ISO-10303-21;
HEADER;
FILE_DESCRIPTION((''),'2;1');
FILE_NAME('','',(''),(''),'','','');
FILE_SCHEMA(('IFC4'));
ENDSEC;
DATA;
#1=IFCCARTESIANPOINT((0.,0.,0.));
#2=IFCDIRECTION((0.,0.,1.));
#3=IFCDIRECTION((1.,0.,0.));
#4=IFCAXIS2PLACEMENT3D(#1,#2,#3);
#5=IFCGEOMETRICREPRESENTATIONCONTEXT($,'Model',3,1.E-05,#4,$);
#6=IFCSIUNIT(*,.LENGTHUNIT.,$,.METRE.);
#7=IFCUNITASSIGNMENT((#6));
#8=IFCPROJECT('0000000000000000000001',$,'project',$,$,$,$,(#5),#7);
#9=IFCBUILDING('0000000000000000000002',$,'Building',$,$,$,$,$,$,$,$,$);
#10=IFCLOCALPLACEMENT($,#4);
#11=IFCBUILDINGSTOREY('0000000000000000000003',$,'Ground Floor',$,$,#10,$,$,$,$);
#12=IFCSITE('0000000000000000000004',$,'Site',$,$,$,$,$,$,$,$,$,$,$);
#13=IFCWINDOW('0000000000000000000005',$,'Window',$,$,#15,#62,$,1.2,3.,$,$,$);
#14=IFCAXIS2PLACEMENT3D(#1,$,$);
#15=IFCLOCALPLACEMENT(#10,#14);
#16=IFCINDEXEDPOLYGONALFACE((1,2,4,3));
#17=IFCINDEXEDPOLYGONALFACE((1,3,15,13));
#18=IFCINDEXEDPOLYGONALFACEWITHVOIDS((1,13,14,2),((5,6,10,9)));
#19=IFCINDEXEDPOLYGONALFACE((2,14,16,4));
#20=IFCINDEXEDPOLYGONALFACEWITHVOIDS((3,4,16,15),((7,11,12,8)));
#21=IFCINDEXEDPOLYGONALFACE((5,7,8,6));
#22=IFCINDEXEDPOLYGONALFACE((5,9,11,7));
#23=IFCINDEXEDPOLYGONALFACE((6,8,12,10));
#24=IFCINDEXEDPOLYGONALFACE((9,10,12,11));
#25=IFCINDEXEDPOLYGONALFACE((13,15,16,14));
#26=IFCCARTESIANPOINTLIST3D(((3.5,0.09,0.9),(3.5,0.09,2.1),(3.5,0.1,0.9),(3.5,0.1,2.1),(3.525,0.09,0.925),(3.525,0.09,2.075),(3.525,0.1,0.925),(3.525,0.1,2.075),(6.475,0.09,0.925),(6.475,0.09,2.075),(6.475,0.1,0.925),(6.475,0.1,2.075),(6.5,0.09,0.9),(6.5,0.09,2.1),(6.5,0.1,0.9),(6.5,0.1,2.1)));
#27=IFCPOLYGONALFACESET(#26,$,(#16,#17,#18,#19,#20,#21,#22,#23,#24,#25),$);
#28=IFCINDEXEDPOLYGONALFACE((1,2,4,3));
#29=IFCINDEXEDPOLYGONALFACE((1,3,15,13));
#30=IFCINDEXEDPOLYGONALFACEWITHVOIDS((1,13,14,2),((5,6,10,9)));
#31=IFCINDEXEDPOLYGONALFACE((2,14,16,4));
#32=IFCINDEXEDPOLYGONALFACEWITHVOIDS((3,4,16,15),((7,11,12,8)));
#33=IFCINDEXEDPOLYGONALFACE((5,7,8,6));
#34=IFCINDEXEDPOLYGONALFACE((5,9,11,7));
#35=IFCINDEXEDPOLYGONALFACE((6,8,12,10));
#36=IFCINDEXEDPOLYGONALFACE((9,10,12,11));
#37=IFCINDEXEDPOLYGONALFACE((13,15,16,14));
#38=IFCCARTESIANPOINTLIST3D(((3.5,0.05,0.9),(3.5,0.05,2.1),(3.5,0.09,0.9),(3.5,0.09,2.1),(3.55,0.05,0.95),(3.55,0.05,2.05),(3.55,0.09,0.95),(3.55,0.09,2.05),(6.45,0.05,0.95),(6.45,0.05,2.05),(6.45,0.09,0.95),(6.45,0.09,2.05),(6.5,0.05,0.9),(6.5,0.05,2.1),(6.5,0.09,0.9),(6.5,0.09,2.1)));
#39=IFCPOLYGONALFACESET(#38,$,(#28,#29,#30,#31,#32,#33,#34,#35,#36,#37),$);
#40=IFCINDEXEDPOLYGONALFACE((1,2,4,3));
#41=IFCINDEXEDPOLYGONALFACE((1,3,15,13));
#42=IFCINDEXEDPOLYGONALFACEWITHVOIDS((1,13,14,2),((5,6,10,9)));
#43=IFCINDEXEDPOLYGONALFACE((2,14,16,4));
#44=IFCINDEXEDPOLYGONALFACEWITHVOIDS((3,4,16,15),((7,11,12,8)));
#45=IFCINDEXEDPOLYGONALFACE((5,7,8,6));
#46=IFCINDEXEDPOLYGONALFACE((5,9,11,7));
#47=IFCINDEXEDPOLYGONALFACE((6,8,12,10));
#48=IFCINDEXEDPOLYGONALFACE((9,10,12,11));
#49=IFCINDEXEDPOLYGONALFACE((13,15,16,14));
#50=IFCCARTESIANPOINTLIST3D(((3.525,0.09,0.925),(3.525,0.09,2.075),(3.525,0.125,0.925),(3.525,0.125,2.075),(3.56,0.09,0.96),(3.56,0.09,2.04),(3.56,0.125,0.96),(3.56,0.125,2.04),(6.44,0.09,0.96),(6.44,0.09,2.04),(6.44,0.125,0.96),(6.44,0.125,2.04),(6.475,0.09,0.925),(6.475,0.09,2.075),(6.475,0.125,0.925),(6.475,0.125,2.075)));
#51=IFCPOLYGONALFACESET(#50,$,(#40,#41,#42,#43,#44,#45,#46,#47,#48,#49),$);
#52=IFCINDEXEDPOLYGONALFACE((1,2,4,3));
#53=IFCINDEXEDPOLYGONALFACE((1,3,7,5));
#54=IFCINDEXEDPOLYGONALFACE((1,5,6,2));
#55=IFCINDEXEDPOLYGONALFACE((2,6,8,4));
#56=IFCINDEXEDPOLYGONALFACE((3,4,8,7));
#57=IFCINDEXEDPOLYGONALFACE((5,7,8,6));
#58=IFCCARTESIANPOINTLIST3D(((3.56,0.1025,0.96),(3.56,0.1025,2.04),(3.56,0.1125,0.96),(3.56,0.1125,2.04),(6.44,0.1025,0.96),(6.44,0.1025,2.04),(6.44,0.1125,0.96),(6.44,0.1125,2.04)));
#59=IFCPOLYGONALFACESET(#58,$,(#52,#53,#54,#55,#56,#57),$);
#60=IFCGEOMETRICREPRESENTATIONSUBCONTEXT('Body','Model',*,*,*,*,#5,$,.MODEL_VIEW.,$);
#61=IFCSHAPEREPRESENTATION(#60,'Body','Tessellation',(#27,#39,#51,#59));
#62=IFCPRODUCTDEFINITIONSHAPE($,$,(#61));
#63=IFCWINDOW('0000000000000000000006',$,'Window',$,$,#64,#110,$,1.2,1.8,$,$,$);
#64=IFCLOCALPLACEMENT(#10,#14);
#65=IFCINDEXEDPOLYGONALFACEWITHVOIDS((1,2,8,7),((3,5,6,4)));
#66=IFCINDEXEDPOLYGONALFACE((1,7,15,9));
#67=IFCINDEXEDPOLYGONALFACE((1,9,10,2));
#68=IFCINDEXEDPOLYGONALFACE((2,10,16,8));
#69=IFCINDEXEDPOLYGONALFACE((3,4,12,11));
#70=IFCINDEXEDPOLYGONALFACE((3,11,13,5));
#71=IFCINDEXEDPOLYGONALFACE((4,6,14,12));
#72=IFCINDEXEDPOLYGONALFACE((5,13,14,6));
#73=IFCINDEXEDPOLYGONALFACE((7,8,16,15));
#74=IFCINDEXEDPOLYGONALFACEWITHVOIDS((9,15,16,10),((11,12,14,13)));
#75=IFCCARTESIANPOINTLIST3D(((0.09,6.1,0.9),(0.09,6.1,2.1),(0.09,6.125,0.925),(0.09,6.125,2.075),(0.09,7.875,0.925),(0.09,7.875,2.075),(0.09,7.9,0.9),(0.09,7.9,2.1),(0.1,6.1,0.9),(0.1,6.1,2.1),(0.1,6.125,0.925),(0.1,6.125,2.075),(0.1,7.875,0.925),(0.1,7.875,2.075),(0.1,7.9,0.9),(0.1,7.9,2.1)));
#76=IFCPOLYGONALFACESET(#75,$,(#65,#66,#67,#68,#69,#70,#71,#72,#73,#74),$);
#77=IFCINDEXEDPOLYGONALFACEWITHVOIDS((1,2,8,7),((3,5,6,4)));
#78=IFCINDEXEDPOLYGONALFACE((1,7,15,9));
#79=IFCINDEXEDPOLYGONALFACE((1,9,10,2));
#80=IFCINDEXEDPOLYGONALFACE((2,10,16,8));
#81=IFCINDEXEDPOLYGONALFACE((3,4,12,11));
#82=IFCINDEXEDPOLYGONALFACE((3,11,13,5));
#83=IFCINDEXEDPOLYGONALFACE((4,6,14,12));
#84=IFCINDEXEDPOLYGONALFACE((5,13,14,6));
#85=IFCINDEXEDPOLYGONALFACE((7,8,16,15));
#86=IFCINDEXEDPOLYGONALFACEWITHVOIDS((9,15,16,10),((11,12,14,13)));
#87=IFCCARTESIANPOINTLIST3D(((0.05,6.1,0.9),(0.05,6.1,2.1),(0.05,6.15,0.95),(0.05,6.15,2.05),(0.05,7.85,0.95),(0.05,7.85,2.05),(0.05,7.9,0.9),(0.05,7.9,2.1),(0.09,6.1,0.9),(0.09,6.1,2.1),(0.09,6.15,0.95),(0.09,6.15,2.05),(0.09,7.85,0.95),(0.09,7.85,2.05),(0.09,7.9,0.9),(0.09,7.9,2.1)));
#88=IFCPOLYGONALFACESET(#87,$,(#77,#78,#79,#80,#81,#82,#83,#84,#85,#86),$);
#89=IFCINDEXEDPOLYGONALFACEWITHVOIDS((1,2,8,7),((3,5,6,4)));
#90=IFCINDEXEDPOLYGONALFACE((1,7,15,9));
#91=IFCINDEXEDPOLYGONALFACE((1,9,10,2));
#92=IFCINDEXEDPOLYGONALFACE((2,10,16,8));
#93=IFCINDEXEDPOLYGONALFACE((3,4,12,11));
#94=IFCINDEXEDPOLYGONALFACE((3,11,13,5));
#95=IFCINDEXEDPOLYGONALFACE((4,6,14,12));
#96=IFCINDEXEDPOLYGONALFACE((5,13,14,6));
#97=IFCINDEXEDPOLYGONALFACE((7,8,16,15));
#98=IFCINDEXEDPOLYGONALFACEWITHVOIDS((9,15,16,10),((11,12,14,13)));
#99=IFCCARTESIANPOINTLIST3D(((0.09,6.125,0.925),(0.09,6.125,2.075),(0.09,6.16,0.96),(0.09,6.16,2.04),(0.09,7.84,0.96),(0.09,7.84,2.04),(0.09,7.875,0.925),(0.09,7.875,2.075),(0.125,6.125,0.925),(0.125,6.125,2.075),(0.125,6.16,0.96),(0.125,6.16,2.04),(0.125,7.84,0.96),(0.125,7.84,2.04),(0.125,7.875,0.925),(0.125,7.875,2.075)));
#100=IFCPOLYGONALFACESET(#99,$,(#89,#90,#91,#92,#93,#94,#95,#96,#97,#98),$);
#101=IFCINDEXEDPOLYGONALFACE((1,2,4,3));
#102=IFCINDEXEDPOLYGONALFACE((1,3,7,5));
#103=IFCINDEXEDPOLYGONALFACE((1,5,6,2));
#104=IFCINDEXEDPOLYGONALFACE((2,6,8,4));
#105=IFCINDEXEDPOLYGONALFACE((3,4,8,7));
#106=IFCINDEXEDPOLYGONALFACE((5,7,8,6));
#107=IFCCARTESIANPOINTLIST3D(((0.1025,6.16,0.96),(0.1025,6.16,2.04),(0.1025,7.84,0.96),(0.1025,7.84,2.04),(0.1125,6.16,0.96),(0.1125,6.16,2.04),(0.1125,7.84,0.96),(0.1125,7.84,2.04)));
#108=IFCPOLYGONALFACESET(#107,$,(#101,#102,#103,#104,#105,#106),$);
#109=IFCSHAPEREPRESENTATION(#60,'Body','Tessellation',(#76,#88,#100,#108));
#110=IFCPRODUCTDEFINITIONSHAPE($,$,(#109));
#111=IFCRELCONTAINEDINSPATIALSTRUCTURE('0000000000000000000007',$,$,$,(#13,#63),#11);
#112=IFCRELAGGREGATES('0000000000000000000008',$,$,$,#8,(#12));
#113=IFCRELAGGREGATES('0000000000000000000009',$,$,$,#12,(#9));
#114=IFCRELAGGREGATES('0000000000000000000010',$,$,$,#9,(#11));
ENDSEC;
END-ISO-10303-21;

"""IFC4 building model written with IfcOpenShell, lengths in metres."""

from ifc_helpers import new_model, si_unit, frame, origin_with_axes, place, context, subcontext, project, spatial, line, indexed_curve, outline, extrude, element, save


model = new_model("IFC4")

# Units and contexts
model_context = context("Model", 3, precision=1e-05, world=origin_with_axes())
body_context = subcontext(model_context, "Body", "Model", "MODEL_VIEW")
ifc_project = project(units=[si_unit("LENGTHUNIT", "METRE")], contexts=[model_context])

# Site, building, storey
site = spatial("IfcSite", under=ifc_project, Name="Site")
building = spatial("IfcBuilding", under=site, Name="Building")
storey_placement = place(None, origin_with_axes())
storey = spatial("IfcBuildingStorey", under=building, at=storey_placement, Name="Ground Floor")

# Windows
window_1_placement = place(storey_placement, frame((3.5, 0.0, 0.9), z_axis=(0.0, 0.0, 1.0), x_axis=(1.0, 0.0, 0.0)))
element("IfcWindow", 1, at=window_1_placement, inside=storey, Name="Window", OverallHeight=1.2, OverallWidth=3.0, context=body_context, shape_type="SweptSolid", body=[
    extrude(outline(indexed_curve([(0.0, 0.0), (3.0, 0.0), (3.0, 1.2), (0.0, 1.2)], segments=[line(1, 2, 3, 4, 1)]), holes=[indexed_curve([(0.025, 0.025), (2.975, 0.025), (2.975, 1.175), (0.025, 1.175)], segments=[line(1, 2, 3, 4, 1)])]), frame((0.0, 0.09, 0.0), z_axis=(0.0, -1.0, 0.0), x_axis=(1.0, 0.0, 0.0)), (0.0, 0.0, -1.0), 0.01),
    extrude(outline(indexed_curve([(0.0, 0.0), (3.0, 0.0), (3.0, 1.2), (0.0, 1.2)], segments=[line(1, 2, 3, 4, 1)]), holes=[indexed_curve([(0.05, 0.05), (2.95, 0.05), (2.95, 1.15), (0.05, 1.15)], segments=[line(1, 2, 3, 4, 1)])]), frame((0.0, 0.05, 0.0), z_axis=(0.0, -1.0, 0.0), x_axis=(1.0, 0.0, 0.0)), (0.0, 0.0, -1.0), 0.04),
    extrude(outline(indexed_curve([(0.0, 0.0), (2.95, 0.0), (2.95, 1.15), (0.0, 1.15)], segments=[line(1, 2, 3, 4, 1)]), holes=[indexed_curve([(0.035, 0.035), (2.915, 0.035), (2.915, 1.115), (0.035, 1.115)], segments=[line(1, 2, 3, 4, 1)])]), frame((0.025, 0.09, 0.025), z_axis=(0.0, -1.0, 0.0), x_axis=(1.0, 0.0, 0.0)), (0.0, 0.0, -1.0), 0.035),
    extrude(outline(indexed_curve([(0.035, 0.035), (2.915, 0.035), (2.915, 1.115), (0.035, 1.115)], segments=[line(1, 2, 3, 4, 1)])), frame((0.025, 0.1025, 0.025), z_axis=(0.0, -1.0, 0.0), x_axis=(1.0, 0.0, 0.0)), (0.0, 0.0, -1.0), 0.01),
])
window_2_placement = place(storey_placement, frame((0.0, 7.9, 0.9), z_axis=(0.0, 0.0, 1.0), x_axis=(0.0, -1.0, 0.0)))
element("IfcWindow", 2, at=window_2_placement, inside=storey, Name="Window", OverallHeight=1.2, OverallWidth=1.8, context=body_context, shape_type="SweptSolid", body=[
    extrude(outline(indexed_curve([(0.0, 0.0), (1.8, 0.0), (1.8, 1.2), (0.0, 1.2)], segments=[line(1, 2, 3, 4, 1)]), holes=[indexed_curve([(0.025, 0.025), (1.775, 0.025), (1.775, 1.175), (0.025, 1.175)], segments=[line(1, 2, 3, 4, 1)])]), frame((0.0, 0.09, 0.0), z_axis=(0.0, -1.0, 0.0), x_axis=(1.0, 0.0, 0.0)), (0.0, 0.0, -1.0), 0.01),
    extrude(outline(indexed_curve([(0.0, 0.0), (1.8, 0.0), (1.8, 1.2), (0.0, 1.2)], segments=[line(1, 2, 3, 4, 1)]), holes=[indexed_curve([(0.05, 0.05), (1.75, 0.05), (1.75, 1.15), (0.05, 1.15)], segments=[line(1, 2, 3, 4, 1)])]), frame((0.0, 0.05, 0.0), z_axis=(0.0, -1.0, 0.0), x_axis=(1.0, 0.0, 0.0)), (0.0, 0.0, -1.0), 0.04),
    extrude(outline(indexed_curve([(0.0, 0.0), (1.75, 0.0), (1.75, 1.15), (0.0, 1.15)], segments=[line(1, 2, 3, 4, 1)]), holes=[indexed_curve([(0.035, 0.035), (1.715, 0.035), (1.715, 1.115), (0.035, 1.115)], segments=[line(1, 2, 3, 4, 1)])]), frame((0.025, 0.09, 0.025), z_axis=(0.0, -1.0, 0.0), x_axis=(1.0, 0.0, 0.0)), (0.0, 0.0, -1.0), 0.035),
    extrude(outline(indexed_curve([(0.035, 0.035), (1.715, 0.035), (1.715, 1.115), (0.035, 1.115)], segments=[line(1, 2, 3, 4, 1)])), frame((0.025, 0.1025, 0.025), z_axis=(0.0, -1.0, 0.0), x_axis=(1.0, 0.0, 0.0)), (0.0, 0.0, -1.0), 0.01),
])

save(model, "model.ifc")
